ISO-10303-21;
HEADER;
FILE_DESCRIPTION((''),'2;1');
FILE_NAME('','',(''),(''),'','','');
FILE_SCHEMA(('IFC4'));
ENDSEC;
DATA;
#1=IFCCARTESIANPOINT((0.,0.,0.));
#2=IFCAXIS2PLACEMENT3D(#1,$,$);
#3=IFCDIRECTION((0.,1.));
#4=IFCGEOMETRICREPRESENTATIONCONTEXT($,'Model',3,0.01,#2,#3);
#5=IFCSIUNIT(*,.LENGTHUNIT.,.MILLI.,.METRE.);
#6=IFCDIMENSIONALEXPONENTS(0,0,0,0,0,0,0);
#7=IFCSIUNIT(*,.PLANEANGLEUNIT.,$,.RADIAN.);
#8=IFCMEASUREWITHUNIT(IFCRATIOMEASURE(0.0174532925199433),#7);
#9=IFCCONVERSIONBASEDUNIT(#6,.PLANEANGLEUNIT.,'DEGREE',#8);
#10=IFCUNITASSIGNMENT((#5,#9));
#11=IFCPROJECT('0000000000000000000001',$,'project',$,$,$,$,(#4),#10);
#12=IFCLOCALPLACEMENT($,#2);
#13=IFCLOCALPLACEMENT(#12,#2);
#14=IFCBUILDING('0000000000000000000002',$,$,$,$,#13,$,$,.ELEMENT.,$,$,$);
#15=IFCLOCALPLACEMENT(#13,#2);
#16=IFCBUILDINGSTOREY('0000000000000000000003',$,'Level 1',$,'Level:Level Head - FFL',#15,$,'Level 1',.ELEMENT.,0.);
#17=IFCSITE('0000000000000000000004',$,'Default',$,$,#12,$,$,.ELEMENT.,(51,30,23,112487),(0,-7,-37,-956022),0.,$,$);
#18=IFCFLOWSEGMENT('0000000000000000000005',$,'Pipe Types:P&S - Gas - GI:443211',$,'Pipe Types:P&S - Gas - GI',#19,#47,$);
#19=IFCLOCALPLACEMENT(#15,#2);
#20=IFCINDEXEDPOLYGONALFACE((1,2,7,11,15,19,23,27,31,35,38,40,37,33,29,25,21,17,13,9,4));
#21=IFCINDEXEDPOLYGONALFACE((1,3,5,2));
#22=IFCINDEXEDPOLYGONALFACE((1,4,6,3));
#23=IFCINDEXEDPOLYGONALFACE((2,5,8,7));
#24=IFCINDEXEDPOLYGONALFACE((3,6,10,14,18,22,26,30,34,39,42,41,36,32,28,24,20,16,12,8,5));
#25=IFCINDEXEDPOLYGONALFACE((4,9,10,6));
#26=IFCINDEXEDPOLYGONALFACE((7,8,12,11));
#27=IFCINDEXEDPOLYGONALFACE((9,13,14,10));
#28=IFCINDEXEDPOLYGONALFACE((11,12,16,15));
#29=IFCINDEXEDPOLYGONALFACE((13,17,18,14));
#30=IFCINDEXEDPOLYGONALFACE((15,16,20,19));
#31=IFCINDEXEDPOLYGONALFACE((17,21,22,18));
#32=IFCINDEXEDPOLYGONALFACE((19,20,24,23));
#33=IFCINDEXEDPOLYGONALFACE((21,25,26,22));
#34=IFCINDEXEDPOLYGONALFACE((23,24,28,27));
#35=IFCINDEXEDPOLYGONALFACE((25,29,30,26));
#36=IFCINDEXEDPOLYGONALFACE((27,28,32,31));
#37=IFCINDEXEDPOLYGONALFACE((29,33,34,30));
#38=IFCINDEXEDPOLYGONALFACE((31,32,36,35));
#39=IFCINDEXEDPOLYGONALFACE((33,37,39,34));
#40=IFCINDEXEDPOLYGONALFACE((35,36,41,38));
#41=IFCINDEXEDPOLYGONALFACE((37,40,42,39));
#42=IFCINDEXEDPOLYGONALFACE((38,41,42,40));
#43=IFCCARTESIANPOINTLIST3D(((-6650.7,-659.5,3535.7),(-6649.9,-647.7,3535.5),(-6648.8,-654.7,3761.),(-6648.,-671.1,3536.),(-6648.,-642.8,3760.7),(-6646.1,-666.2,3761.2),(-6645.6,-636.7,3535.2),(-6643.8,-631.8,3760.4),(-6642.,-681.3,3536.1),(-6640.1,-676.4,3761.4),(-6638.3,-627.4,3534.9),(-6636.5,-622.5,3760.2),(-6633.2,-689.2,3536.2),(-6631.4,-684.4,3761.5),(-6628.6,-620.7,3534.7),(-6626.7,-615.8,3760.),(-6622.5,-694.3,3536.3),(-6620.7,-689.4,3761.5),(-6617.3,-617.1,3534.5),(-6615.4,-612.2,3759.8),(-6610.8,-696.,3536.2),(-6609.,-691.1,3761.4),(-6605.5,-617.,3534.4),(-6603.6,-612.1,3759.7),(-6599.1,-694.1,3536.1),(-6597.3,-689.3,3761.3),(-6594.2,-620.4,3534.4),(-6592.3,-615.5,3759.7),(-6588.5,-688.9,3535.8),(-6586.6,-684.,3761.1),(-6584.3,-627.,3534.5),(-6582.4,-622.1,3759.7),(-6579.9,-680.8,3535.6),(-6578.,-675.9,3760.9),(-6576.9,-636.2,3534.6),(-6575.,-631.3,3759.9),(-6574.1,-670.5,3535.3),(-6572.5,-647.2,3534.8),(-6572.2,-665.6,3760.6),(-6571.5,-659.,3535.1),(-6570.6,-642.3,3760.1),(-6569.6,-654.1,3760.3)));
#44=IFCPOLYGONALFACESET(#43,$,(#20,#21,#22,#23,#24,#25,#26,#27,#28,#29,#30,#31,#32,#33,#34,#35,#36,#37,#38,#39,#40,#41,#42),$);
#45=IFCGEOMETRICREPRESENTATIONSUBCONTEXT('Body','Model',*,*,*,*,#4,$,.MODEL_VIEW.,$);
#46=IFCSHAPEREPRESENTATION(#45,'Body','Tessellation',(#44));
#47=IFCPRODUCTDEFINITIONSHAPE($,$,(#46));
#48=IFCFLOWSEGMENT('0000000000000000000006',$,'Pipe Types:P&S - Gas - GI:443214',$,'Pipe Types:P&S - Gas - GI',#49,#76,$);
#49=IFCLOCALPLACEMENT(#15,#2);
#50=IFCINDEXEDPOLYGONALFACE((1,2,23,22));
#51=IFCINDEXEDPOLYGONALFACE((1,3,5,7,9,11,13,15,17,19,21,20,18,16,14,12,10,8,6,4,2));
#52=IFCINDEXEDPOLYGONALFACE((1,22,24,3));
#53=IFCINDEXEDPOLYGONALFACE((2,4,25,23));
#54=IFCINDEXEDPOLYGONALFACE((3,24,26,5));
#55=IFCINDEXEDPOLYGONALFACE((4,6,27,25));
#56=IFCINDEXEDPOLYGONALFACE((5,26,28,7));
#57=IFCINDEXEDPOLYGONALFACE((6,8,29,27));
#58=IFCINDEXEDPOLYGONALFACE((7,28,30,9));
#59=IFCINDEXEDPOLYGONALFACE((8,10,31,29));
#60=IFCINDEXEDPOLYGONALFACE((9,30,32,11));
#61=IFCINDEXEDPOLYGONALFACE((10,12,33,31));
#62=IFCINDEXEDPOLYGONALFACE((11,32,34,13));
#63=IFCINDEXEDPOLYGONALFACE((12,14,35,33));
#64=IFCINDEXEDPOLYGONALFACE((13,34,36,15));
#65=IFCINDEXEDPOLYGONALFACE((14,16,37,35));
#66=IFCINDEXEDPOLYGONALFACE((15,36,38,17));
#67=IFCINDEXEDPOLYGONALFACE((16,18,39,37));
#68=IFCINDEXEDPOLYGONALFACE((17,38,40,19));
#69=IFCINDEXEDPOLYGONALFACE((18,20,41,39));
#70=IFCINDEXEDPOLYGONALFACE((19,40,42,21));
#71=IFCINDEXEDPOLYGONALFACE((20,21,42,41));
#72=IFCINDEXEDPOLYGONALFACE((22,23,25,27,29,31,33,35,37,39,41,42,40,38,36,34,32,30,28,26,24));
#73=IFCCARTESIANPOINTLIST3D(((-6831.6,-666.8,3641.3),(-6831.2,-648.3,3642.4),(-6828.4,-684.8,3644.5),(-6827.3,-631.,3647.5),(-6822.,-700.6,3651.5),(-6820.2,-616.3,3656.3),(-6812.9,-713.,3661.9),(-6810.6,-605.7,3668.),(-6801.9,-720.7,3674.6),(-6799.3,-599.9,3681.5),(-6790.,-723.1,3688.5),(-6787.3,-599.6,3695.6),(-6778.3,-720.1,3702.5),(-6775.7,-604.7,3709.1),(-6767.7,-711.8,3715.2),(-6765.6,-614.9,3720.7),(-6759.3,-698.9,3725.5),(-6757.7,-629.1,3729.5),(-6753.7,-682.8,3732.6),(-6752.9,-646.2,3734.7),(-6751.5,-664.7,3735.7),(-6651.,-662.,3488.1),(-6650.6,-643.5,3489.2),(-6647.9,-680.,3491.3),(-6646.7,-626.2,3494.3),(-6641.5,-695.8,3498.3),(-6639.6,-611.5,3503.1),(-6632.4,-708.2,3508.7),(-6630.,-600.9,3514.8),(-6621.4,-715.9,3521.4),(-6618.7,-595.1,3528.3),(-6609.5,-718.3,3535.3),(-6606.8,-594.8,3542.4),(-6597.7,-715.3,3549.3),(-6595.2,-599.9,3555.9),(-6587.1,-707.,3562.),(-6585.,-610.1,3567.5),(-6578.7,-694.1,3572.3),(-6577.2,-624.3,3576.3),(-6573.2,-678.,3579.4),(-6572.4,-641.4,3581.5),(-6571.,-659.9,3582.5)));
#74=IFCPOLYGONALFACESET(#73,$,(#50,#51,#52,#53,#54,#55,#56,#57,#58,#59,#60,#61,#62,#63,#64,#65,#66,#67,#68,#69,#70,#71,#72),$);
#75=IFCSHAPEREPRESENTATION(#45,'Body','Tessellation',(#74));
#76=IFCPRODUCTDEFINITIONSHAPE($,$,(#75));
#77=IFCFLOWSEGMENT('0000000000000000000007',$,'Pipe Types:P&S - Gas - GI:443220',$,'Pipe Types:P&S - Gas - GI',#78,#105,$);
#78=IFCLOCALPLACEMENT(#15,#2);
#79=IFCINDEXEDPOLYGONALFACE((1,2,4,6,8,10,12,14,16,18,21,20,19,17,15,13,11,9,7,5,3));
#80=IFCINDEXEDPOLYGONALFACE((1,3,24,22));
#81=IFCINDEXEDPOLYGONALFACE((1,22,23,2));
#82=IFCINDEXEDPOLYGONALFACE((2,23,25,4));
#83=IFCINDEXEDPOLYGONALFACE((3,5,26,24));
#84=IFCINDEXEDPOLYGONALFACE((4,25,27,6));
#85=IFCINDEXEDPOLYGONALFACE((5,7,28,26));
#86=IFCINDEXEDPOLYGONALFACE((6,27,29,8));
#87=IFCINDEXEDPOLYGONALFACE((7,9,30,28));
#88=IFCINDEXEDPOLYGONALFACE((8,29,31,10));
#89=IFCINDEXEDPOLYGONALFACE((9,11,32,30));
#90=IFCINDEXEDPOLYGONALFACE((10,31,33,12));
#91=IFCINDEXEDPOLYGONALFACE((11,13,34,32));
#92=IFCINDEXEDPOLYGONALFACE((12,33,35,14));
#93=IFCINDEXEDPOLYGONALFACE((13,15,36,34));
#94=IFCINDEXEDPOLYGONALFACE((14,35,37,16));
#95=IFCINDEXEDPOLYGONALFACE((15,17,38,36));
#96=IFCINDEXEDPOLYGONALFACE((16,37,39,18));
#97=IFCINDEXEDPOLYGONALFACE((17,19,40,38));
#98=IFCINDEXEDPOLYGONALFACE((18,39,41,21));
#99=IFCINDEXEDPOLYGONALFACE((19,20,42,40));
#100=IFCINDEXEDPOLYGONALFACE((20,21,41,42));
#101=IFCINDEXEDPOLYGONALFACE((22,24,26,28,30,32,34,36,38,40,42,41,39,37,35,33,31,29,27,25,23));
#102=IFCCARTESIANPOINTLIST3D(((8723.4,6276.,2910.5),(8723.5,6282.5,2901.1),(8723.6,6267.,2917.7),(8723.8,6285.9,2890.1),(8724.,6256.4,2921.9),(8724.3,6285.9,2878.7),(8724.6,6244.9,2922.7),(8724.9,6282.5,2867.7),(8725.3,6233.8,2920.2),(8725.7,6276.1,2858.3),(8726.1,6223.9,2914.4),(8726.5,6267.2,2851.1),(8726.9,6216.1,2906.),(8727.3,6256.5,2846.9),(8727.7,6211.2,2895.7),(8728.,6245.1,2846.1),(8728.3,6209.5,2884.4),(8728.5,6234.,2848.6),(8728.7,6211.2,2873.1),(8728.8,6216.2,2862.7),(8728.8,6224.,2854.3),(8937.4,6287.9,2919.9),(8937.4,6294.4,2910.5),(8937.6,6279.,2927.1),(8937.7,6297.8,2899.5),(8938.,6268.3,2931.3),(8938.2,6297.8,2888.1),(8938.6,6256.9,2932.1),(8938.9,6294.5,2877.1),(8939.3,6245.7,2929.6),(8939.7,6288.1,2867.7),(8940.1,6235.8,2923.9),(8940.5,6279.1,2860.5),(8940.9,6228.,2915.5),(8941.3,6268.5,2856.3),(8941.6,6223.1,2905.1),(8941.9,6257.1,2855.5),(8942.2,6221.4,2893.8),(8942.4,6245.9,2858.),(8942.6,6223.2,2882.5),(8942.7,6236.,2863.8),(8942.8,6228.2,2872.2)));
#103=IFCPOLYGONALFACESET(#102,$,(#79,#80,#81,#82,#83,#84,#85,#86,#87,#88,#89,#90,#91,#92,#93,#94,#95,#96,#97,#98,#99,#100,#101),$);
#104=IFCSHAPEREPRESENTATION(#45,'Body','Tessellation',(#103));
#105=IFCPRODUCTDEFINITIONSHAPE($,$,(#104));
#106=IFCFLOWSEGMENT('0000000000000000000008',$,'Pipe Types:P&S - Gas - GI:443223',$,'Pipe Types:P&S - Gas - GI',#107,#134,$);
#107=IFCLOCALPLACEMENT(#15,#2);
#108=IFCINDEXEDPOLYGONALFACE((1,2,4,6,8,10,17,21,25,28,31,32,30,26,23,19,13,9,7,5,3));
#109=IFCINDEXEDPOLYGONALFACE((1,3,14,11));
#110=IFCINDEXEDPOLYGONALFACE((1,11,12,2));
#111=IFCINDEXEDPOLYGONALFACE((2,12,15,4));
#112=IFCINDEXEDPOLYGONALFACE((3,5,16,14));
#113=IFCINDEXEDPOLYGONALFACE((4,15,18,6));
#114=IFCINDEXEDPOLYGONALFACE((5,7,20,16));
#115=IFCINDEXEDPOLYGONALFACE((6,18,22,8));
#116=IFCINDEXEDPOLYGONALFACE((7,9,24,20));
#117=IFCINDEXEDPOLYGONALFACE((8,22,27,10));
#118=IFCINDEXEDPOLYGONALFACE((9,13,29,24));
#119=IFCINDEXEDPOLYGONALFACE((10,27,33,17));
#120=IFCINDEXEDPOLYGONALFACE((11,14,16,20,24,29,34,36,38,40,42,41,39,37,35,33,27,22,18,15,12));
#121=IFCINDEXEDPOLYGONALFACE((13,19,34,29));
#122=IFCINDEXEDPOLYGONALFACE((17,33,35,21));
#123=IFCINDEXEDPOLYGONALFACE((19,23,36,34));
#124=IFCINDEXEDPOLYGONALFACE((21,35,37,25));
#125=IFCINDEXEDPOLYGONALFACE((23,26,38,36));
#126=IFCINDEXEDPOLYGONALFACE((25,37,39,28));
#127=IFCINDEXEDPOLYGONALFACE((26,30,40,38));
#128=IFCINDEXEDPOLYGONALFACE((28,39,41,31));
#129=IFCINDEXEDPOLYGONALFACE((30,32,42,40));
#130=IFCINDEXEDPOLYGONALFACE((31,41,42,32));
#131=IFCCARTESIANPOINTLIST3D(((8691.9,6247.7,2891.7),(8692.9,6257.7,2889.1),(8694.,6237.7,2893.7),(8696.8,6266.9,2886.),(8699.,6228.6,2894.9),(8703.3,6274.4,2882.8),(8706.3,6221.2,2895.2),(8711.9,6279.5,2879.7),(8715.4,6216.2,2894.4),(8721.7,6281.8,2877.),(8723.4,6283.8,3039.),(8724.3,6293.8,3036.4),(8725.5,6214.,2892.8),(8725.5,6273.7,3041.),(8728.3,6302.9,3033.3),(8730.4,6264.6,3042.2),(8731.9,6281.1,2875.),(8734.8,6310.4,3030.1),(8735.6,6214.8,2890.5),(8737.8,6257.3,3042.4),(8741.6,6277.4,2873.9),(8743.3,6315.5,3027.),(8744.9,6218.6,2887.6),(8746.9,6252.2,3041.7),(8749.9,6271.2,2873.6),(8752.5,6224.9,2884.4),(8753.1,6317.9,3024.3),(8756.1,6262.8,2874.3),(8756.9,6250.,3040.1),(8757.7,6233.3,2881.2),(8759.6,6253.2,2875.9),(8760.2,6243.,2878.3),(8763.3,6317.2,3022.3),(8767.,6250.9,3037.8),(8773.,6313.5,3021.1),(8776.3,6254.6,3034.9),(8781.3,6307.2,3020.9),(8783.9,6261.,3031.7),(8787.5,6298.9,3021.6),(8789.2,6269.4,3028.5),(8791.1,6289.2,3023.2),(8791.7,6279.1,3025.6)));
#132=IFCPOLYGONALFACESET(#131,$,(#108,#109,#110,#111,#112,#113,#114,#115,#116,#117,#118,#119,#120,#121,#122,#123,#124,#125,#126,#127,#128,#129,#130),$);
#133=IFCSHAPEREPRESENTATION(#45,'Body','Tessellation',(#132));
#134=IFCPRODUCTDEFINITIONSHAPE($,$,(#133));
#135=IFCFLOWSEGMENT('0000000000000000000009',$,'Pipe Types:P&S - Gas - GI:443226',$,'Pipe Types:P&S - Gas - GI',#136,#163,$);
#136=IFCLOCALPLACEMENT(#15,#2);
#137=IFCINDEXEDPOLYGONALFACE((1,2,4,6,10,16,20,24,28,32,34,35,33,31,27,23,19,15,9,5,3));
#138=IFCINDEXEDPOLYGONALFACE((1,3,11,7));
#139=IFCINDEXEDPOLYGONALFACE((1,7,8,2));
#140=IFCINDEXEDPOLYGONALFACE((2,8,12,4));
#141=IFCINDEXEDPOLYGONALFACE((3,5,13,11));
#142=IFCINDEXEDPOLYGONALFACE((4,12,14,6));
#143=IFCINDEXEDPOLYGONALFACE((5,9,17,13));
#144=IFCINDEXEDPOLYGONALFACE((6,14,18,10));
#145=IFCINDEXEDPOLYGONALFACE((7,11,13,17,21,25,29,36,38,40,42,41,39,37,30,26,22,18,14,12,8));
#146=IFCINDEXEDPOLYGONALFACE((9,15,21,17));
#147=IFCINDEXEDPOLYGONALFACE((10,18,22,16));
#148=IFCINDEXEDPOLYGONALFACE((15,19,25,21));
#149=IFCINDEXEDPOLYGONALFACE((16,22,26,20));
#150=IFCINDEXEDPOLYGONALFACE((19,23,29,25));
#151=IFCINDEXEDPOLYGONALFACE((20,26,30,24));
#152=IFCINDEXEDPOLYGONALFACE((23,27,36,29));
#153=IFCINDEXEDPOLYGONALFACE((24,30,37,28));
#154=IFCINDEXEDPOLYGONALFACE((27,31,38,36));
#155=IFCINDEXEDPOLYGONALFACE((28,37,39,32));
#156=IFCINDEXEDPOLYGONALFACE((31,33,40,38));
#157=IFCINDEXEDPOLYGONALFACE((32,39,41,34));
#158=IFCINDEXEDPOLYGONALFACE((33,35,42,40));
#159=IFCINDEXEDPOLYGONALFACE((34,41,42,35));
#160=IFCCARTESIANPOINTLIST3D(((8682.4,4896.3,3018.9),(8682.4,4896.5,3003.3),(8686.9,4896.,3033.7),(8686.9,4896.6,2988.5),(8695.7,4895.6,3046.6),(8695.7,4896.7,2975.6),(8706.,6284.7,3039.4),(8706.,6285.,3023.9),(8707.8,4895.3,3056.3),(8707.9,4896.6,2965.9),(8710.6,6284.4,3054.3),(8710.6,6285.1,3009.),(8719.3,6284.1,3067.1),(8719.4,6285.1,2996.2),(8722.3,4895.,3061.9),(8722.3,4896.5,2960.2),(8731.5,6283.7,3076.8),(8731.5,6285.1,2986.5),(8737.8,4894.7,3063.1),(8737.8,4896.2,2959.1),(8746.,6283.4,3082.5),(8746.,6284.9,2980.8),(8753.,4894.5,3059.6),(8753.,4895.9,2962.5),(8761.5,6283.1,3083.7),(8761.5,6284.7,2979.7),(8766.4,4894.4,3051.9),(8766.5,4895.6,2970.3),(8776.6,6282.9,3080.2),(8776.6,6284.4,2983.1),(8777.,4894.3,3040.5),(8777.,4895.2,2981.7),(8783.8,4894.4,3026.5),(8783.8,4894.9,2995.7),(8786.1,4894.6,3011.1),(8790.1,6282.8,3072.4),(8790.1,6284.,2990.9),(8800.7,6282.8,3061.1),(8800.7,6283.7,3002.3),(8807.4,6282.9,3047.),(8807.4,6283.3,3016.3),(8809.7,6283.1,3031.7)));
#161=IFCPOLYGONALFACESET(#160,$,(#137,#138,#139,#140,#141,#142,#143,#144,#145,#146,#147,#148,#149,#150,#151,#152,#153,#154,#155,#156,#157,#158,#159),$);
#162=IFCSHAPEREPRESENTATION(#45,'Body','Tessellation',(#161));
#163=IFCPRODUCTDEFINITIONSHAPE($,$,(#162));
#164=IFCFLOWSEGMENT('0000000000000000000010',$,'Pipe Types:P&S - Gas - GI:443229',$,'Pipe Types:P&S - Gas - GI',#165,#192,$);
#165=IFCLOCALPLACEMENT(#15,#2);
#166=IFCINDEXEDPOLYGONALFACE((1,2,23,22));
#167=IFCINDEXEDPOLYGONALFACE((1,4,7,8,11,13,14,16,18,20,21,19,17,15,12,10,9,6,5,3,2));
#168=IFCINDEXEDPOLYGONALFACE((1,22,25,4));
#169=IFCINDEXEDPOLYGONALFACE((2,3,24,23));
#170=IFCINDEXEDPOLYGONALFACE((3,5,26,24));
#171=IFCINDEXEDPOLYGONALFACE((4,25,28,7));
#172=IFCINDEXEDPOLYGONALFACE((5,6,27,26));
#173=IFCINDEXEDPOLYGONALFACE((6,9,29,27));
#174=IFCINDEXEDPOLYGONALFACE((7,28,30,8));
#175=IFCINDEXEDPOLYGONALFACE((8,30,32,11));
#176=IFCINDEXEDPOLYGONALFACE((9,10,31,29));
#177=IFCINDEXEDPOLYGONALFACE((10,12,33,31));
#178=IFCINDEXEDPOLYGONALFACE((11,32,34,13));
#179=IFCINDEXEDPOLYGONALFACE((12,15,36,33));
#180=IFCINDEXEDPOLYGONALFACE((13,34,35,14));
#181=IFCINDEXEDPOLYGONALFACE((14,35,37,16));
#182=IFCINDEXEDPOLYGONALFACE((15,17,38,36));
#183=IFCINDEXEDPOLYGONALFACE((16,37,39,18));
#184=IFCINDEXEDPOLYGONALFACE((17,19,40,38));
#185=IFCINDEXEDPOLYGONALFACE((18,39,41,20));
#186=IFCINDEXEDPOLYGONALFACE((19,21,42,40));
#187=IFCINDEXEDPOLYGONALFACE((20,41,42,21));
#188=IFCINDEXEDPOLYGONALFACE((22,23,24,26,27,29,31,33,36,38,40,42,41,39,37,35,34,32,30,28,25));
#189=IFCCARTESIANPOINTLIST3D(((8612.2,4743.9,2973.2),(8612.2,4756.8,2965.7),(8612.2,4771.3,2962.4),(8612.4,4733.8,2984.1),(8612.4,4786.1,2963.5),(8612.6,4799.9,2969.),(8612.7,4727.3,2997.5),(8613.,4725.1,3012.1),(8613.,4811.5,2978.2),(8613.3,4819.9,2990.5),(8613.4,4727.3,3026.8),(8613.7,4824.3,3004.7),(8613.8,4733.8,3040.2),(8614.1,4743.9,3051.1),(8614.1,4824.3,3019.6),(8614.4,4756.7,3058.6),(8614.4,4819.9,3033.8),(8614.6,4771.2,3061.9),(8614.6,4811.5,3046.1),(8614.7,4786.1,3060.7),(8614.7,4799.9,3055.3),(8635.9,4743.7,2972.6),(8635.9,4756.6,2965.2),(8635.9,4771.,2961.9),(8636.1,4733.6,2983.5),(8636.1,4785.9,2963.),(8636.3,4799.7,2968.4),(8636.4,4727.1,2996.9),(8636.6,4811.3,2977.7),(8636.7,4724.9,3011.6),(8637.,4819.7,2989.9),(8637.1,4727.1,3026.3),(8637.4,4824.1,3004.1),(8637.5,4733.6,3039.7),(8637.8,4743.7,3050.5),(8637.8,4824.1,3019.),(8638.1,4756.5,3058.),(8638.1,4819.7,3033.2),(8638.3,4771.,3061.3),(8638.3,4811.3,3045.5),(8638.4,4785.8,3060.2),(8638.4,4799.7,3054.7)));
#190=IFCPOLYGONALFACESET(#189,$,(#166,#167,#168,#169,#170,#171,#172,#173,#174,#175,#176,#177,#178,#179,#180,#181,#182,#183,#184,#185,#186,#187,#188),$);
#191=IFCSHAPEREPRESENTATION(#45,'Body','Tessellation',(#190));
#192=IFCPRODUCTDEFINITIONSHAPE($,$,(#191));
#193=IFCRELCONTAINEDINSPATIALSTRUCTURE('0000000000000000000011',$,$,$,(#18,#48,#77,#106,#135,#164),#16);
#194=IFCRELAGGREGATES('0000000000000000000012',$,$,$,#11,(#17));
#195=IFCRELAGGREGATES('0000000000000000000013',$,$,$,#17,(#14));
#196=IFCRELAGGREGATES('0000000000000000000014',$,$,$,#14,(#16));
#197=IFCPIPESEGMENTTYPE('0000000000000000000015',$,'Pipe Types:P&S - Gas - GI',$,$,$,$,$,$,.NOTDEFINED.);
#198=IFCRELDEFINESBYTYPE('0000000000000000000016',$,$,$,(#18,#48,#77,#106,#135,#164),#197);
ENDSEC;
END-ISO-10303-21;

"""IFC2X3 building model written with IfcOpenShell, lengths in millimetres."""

from ifc_helpers import new_model, entity, si_unit, converted_unit, direction, frame, frame_2d, origin, origin_2d_with_axis, place, context, subcontext, project, spatial, circle, extrude, type_object, element, save


model = new_model("IFC2X3")

# Units and contexts
model_context = context("Model", 3, precision=0.01, world=origin(), true_north=direction((0.0, 1.0)))
body_context = subcontext(model_context, "Body", "Model", "MODEL_VIEW")
ifc_project = project(units=[si_unit("LENGTHUNIT", "METRE", prefix="MILLI"), converted_unit("PLANEANGLEUNIT", "DEGREE", entity("IfcRatioMeasure", 0.0174532925199433), si_unit("PLANEANGLEUNIT", "RADIAN"), dimensions=[0, 0, 0, 0, 0, 0, 0])], contexts=[model_context])

# Site, building, storey
site_placement = place(None, origin())
site = spatial("IfcSite", under=ifc_project, at=site_placement, Name="Default", CompositionType="ELEMENT", RefLatitude=(51, 30, 23, 112487), RefLongitude=(0, -7, -37, -956022), RefElevation=0.0)
building_placement = place(site_placement, origin())
building = spatial("IfcBuilding", under=site, at=building_placement, CompositionType="ELEMENT")
storey_placement = place(building_placement, origin())
storey = spatial("IfcBuildingStorey", under=building, at=storey_placement, Name="Level 1", ObjectType="Level:Level Head - FFL", LongName="Level 1", CompositionType="ELEMENT", Elevation=0.0)

# Flow segments
pipe_segment_type = type_object("IfcPipeSegmentType", Name="Pipe Types:P&S - Gas - GI", PredefinedType="NOTDEFINED")
flow_segment_1_placement = place(storey_placement, origin())
element("IfcFlowSegment", 1, at=flow_segment_1_placement, inside=storey, type_object=pipe_segment_type, Name="Pipe Types:P&S - Gas - GI:443211", ObjectType="Pipe Types:P&S - Gas - GI", context=body_context, shape_type="SweptSolid", body=[
    extrude(circle(Radius=39.7, at=frame_2d((0.0, 0.0), x_axis=(1.0, 0.0))), frame((-6611.1, -656.3, 3535.3), z_axis=(0.008333, 0.021687, 0.99973), x_axis=(0.933462, -0.358676, 0.0)), (0.0, 0.0, 1.0), 225.3),
])
flow_segment_2_placement = place(storey_placement, origin())
element("IfcFlowSegment", 2, at=flow_segment_2_placement, inside=storey, type_object=pipe_segment_type, Name="Pipe Types:P&S - Gas - GI:443214", ObjectType="Pipe Types:P&S - Gas - GI", context=body_context, shape_type="SweptSolid", body=[
    extrude(circle(Radius=62.1, at=frame_2d((0.0, 0.0), x_axis=(1.0, 0.0))), frame((-6791.7, -661.1, 3688.5), z_axis=(0.762367, 0.020254, -0.646828), x_axis=(0.026558, -0.999647, 0.0)), (0.0, 0.0, 1.0), 236.8),
])
flow_segment_3_placement = place(storey_placement, origin())
element("IfcFlowSegment", 3, at=flow_segment_3_placement, inside=storey, type_object=pipe_segment_type, Name="Pipe Types:P&S - Gas - GI:443220", ObjectType="Pipe Types:P&S - Gas - GI", context=body_context, shape_type="SweptSolid", body=[
    extrude(circle(Radius=38.5, at=origin_2d_with_axis()), frame((8726.1, 6247.9, 2884.4), z_axis=(0.997486, 0.055654, 0.043873), x_axis=(0.055707, -0.998447, 0.0)), (0.0, 0.0, 1.0), 214.5),
])
flow_segment_4_placement = place(storey_placement, origin())
element("IfcFlowSegment", 4, at=flow_segment_4_placement, inside=storey, type_object=pipe_segment_type, Name="Pipe Types:P&S - Gas - GI:443223", ObjectType="Pipe Types:P&S - Gas - GI", context=body_context, shape_type="SweptSolid", body=[
    extrude(circle(Radius=35.0, at=origin_2d_with_axis()), frame((8726.1, 6247.9, 2884.4), z_axis=(0.203047, 0.232907, 0.951066), x_axis=(0.753773, -0.657135, 0.0)), (0.0, 0.0, 1.0), 154.9),
])
flow_segment_5_placement = place(storey_placement, origin())
element("IfcFlowSegment", 5, at=flow_segment_5_placement, inside=storey, type_object=pipe_segment_type, Name="Pipe Types:P&S - Gas - GI:443226", ObjectType="Pipe Types:P&S - Gas - GI", context=body_context, shape_type="SweptSolid", body=[
    extrude(circle(Radius=52.2, at=frame_2d((0.0, 0.0), x_axis=(1.0, 0.0))), frame((8733.9, 4895.5, 3011.1), z_axis=(0.017023, 0.999745, 0.014823), x_axis=(0.999855, -0.017025, 0.0)), (0.0, 0.0, 1.0), 1388.8),
])
flow_segment_6_placement = place(storey_placement, origin())
element("IfcFlowSegment", 6, at=flow_segment_6_placement, inside=storey, type_object=pipe_segment_type, Name="Pipe Types:P&S - Gas - GI:443229", ObjectType="Pipe Types:P&S - Gas - GI", context=body_context, shape_type="SweptSolid", body=[
    extrude(circle(Radius=49.9, at=origin_2d_with_axis()), frame((8637.1, 4774.8, 3011.6), z_axis=(-0.999669, 0.008846, 0.024151), x_axis=(-0.008849, -0.999961, 0.0)), (0.0, 0.0, 1.0), 23.7),
])

save(model, "model.ifc")
